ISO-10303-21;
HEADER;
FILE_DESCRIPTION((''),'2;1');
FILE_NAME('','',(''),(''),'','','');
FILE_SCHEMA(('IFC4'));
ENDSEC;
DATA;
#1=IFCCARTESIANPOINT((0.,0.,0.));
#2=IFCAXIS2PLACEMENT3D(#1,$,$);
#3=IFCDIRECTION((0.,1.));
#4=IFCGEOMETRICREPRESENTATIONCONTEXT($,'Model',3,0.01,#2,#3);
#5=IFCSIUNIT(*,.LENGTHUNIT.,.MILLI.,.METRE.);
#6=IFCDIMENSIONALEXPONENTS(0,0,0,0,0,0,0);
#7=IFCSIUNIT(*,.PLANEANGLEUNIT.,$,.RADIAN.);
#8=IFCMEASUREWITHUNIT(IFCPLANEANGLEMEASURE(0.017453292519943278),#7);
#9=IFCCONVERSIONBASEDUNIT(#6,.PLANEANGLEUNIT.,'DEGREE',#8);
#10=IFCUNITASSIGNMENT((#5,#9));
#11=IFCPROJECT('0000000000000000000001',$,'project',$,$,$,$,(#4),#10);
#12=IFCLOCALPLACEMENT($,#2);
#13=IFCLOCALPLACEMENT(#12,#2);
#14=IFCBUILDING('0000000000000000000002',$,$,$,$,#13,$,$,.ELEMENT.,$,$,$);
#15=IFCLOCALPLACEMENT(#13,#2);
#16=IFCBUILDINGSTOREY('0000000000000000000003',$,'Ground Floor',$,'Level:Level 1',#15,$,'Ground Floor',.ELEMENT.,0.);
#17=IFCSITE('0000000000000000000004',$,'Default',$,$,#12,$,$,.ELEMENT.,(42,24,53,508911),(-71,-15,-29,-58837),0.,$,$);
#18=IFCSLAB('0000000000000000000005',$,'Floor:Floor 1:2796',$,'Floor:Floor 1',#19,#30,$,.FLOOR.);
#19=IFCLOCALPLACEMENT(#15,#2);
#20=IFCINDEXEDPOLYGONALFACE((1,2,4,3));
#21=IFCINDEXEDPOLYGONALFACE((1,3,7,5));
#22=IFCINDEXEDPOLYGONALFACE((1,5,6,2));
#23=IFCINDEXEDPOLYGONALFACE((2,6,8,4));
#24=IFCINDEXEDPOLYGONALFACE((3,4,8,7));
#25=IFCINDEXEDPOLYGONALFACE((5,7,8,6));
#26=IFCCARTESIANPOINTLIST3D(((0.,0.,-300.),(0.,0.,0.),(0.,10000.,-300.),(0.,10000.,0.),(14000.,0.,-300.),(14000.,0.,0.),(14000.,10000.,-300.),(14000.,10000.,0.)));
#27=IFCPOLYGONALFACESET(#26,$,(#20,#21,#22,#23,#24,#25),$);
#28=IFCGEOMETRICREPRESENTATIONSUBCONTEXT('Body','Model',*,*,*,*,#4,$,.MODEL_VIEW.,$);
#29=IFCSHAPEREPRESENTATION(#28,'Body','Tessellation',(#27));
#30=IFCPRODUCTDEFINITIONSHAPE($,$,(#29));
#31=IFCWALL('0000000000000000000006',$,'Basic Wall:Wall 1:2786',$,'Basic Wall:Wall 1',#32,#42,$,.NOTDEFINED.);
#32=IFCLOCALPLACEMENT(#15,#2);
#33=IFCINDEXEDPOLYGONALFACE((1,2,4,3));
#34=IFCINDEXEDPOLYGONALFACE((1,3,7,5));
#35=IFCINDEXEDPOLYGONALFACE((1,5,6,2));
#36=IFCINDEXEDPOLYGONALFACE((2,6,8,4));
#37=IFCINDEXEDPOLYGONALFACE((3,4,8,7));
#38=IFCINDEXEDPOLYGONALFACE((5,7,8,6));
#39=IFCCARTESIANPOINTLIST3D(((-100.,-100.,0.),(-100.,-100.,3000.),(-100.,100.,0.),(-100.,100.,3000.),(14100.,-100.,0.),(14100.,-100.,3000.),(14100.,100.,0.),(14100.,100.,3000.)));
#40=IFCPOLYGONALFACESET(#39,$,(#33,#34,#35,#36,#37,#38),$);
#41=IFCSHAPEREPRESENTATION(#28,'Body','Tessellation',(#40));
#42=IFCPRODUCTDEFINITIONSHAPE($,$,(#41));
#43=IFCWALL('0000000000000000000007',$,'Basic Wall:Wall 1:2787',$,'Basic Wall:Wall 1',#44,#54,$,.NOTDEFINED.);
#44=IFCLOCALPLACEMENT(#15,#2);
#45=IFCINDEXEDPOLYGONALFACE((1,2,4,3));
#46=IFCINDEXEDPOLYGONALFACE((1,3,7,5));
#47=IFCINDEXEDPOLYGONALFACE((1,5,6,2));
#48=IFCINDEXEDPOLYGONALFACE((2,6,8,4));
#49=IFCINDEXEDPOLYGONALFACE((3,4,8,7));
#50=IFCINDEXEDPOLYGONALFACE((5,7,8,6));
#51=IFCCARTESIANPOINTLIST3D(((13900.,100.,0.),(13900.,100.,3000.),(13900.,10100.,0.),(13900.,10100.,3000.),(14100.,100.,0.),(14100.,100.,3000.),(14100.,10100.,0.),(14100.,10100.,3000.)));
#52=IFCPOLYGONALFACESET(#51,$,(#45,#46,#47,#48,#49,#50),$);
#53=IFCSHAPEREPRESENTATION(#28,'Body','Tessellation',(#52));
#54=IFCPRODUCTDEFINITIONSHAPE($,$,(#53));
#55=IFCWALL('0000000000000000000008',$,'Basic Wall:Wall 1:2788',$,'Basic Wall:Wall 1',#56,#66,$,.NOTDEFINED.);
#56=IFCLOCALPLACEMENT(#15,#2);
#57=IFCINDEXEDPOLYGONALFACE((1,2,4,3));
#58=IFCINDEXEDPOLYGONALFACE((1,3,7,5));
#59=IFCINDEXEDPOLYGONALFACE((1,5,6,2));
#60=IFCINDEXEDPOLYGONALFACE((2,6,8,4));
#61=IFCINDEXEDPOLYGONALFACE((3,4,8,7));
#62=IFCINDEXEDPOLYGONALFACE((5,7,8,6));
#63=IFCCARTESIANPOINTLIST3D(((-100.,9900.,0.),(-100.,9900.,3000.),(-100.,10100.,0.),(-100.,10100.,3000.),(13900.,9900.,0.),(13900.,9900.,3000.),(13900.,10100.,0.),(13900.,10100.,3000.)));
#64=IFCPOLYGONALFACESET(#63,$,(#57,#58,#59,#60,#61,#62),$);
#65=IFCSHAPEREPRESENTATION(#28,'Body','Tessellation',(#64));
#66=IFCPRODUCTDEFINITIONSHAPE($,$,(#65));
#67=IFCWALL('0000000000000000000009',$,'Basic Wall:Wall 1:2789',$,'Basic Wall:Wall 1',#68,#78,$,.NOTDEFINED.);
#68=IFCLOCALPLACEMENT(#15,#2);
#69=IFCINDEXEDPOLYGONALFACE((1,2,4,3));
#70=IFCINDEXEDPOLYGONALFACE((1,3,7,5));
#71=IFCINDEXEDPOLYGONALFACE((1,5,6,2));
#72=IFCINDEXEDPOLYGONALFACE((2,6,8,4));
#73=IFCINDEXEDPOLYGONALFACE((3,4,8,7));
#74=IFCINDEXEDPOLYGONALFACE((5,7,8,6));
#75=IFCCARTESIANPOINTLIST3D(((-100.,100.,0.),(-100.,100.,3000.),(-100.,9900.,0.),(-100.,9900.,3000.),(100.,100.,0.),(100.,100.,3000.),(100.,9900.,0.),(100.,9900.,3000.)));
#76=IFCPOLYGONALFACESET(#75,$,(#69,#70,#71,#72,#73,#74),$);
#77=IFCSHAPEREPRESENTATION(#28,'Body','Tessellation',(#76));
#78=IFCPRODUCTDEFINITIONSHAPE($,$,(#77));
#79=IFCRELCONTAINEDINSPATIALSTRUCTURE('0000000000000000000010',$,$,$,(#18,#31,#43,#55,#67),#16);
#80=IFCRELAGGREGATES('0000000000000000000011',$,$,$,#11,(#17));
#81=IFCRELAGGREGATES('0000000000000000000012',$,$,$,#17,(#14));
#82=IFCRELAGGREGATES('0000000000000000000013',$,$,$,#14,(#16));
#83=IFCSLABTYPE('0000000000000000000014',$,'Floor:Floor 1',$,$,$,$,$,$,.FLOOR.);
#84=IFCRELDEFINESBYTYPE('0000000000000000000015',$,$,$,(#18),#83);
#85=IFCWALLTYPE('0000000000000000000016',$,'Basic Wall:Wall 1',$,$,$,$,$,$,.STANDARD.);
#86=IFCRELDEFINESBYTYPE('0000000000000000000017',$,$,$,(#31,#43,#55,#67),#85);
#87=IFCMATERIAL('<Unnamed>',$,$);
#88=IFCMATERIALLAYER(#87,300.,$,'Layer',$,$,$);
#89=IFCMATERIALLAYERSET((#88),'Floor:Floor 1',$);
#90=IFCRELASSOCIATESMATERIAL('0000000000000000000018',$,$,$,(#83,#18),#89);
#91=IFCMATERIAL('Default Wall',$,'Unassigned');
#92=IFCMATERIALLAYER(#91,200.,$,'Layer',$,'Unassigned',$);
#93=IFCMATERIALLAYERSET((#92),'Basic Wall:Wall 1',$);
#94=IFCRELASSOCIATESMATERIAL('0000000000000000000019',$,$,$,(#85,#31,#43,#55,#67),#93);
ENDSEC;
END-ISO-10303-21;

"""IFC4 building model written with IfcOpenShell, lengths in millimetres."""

from ifc_helpers import new_model, entity, si_unit, converted_unit, direction, frame, frame_2d, origin, origin_2d_with_axis, place, context, subcontext, project, spatial, rectangle, extrude, material, layer, layer_set, layer_usage, type_object, element, save


model = new_model("IFC4")

# Units and contexts
model_context = context("Model", 3, precision=0.01, world=origin(), true_north=direction((0.0, 1.0)))
body_context = subcontext(model_context, "Body", "Model", "MODEL_VIEW")
ifc_project = project(units=[si_unit("LENGTHUNIT", "METRE", prefix="MILLI"), converted_unit("PLANEANGLEUNIT", "DEGREE", entity("IfcPlaneAngleMeasure", 0.017453292519943278), si_unit("PLANEANGLEUNIT", "RADIAN"), dimensions=[0, 0, 0, 0, 0, 0, 0])], contexts=[model_context])

# Site, building, storey
site_placement = place(None, origin())
site = spatial("IfcSite", under=ifc_project, at=site_placement, Name="Default", CompositionType="ELEMENT", RefLatitude=(42, 24, 53, 508911), RefLongitude=(-71, -15, -29, -58837), RefElevation=0.0)
building_placement = place(site_placement, origin())
building = spatial("IfcBuilding", under=site, at=building_placement, CompositionType="ELEMENT")
storey_placement = place(building_placement, origin())
storey = spatial("IfcBuildingStorey", under=building, at=storey_placement, Name="Ground Floor", ObjectType="Level:Level 1", LongName="Ground Floor", CompositionType="ELEMENT", Elevation=0.0)

# Slab
ifc_material_1 = material(Name="<Unnamed>")
ifc_layer_1 = layer(ifc_material_1, 300.0, Name="Layer")
ifc_layer_set_1 = layer_set([ifc_layer_1], Name="Floor:Floor 1")
ifc_layer_usage_1 = layer_usage(ifc_layer_set_1, "AXIS3", "POSITIVE", 0.0)
slab_type = type_object("IfcSlabType", Name="Floor:Floor 1", PredefinedType="FLOOR", material=ifc_layer_set_1)
slab_placement = place(storey_placement, origin())
element("IfcSlab", 1, at=slab_placement, inside=storey, type_object=slab_type, material=ifc_layer_usage_1, Name="Floor:Floor 1:2796", ObjectType="Floor:Floor 1", PredefinedType="FLOOR", context=body_context, shape_type="SweptSolid", body=[
    extrude(rectangle(XDim=10000.0, YDim=14000.0, at=origin_2d_with_axis()), frame((7000.0, 5000.0, 0.0), z_axis=(0.0, 0.0, -1.0), x_axis=(0.0, 1.0, 0.0)), (0.0, 0.0, 1.0), 300.0),
])

# Walls
ifc_material_2 = material(Name="Default Wall", Category="Unassigned")
ifc_layer_2 = layer(ifc_material_2, 200.0, Name="Layer", Category="Unassigned")
ifc_layer_set_2 = layer_set([ifc_layer_2], Name="Basic Wall:Wall 1")
ifc_layer_usage_2 = layer_usage(ifc_layer_set_2, "AXIS2", "NEGATIVE", 100.0)
wall_type = type_object("IfcWallType", Name="Basic Wall:Wall 1", PredefinedType="STANDARD", material=ifc_layer_set_2)
wall_1_placement = place(storey_placement, frame((-100.0, 0.0, 0.0)))
element("IfcWall", 2, at=wall_1_placement, inside=storey, type_object=wall_type, material=ifc_layer_usage_2, Name="Basic Wall:Wall 1:2786", ObjectType="Basic Wall:Wall 1", PredefinedType="NOTDEFINED", context=body_context, shape_type="SweptSolid", body=[
    extrude(rectangle(XDim=14200.0, YDim=200.0, at=frame_2d((7100.0, 0.0), x_axis=(-1.0, 0.0))), origin(), (0.0, 0.0, 1.0), 3000.0),
])
ifc_layer_usage_3 = layer_usage(ifc_layer_set_2, "AXIS2", "NEGATIVE", 100.0)
wall_2_placement = place(storey_placement, frame((14000.0, 100.0, 0.0), z_axis=(0.0, 0.0, 1.0), x_axis=(0.0, 1.0, 0.0)))
element("IfcWall", 3, at=wall_2_placement, inside=storey, type_object=wall_type, material=ifc_layer_usage_3, Name="Basic Wall:Wall 1:2787", ObjectType="Basic Wall:Wall 1", PredefinedType="NOTDEFINED", context=body_context, shape_type="SweptSolid", body=[
    extrude(rectangle(XDim=10000.0, YDim=200.0, at=frame_2d((5000.0, 0.0), x_axis=(-1.0, 0.0))), origin(), (0.0, 0.0, 1.0), 3000.0),
])
ifc_layer_usage_4 = layer_usage(ifc_layer_set_2, "AXIS2", "NEGATIVE", 100.0)
wall_3_placement = place(storey_placement, frame((13900.0, 10000.0, 0.0), z_axis=(0.0, 0.0, 1.0), x_axis=(-1.0, 0.0, 0.0)))
element("IfcWall", 4, at=wall_3_placement, inside=storey, type_object=wall_type, material=ifc_layer_usage_4, Name="Basic Wall:Wall 1:2788", ObjectType="Basic Wall:Wall 1", PredefinedType="NOTDEFINED", context=body_context, shape_type="SweptSolid", body=[
    extrude(rectangle(XDim=14000.0, YDim=200.0, at=frame_2d((7000.0, 0.0), x_axis=(-1.0, 0.0))), origin(), (0.0, 0.0, 1.0), 3000.0),
])
ifc_layer_usage_5 = layer_usage(ifc_layer_set_2, "AXIS2", "NEGATIVE", 100.0)
wall_4_placement = place(storey_placement, frame((0.0, 9900.0, 0.0), z_axis=(0.0, 0.0, 1.0), x_axis=(0.0, -1.0, 0.0)))
element("IfcWall", 5, at=wall_4_placement, inside=storey, type_object=wall_type, material=ifc_layer_usage_5, Name="Basic Wall:Wall 1:2789", ObjectType="Basic Wall:Wall 1", PredefinedType="NOTDEFINED", context=body_context, shape_type="SweptSolid", body=[
    extrude(rectangle(XDim=9800.0, YDim=200.0, at=frame_2d((4900.0, 0.0), x_axis=(-1.0, 0.0))), origin(), (0.0, 0.0, 1.0), 3000.0),
])

save(model, "model.ifc")
